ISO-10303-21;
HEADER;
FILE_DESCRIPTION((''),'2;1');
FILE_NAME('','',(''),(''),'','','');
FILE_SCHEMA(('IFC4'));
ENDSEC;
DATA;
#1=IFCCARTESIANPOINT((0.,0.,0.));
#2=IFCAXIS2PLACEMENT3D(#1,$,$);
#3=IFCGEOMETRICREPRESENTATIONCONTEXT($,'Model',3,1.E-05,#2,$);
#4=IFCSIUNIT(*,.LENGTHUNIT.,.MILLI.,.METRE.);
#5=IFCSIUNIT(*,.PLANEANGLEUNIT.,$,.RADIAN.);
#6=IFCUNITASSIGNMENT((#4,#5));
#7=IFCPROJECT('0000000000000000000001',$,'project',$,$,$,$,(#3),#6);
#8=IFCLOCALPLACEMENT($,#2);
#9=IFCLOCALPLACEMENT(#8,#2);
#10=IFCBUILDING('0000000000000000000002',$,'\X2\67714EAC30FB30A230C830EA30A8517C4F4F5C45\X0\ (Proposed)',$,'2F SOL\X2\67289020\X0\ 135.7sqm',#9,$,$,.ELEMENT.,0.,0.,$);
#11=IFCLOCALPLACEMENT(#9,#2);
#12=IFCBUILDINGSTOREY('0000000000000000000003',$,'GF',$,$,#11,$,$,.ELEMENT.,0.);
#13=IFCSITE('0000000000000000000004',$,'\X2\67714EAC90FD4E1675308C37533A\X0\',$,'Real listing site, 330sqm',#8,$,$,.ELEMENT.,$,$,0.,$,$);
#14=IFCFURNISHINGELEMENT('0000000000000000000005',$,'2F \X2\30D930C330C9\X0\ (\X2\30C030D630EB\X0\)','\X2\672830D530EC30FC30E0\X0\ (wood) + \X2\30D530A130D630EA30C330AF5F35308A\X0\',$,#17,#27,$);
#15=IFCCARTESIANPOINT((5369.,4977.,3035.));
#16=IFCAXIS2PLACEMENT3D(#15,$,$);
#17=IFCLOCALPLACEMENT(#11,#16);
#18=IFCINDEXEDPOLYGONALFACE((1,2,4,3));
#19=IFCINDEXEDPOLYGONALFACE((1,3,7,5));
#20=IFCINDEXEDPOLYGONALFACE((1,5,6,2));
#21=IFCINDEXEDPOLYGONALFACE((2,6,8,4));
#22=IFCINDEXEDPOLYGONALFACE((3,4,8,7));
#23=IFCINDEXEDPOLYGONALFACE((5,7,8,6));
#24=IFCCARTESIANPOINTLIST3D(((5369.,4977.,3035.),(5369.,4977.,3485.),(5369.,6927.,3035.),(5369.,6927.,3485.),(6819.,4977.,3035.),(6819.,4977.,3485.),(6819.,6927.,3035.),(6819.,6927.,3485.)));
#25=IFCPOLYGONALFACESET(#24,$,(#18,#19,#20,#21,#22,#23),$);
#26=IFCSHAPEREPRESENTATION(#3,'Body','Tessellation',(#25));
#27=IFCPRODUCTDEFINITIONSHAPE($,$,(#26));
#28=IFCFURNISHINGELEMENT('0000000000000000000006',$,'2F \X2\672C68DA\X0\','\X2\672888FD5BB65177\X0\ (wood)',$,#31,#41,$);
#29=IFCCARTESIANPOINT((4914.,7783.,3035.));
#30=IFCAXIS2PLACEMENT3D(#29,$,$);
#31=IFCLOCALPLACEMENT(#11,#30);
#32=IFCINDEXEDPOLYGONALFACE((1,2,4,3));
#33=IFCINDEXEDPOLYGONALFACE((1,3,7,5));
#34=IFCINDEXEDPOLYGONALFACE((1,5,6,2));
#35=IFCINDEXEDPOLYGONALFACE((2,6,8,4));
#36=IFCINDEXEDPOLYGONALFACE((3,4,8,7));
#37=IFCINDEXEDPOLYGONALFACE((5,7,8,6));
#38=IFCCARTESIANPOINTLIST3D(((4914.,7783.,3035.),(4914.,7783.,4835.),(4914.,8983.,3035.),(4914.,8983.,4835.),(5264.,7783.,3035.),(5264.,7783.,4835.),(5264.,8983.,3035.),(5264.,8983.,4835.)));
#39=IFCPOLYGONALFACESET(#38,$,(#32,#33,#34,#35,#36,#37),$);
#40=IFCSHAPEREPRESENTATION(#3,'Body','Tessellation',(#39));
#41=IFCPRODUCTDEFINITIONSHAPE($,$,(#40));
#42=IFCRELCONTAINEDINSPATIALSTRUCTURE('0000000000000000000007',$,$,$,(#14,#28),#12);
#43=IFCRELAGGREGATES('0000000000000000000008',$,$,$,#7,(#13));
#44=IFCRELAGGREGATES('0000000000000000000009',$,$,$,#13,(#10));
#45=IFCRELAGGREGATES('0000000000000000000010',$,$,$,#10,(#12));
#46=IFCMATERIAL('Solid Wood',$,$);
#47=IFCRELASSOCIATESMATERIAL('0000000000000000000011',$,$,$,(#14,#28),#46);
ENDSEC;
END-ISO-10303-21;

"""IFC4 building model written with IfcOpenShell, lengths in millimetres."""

from ifc_helpers import new_model, si_unit, frame, frame_2d, origin, place, context, project, spatial, rectangle, extrude, material, element, save


model = new_model("IFC4")

# Units and contexts
model_context = context("Model", 3, precision=1e-05, world=origin())
ifc_project = project(units=[si_unit("LENGTHUNIT", "METRE", prefix="MILLI"), si_unit("PLANEANGLEUNIT", "RADIAN")], contexts=[model_context])

# Site, building, storey
site_placement = place(None, origin())
site = spatial("IfcSite", under=ifc_project, at=site_placement, Name="東京都世田谷区", ObjectType="Real listing site, 330sqm", CompositionType="ELEMENT", RefElevation=0.0)
building_placement = place(site_placement, origin())
building = spatial("IfcBuilding", under=site, at=building_placement, Name="東京・アトリエ兼住居 (Proposed)", ObjectType="2F SOL木造 135.7sqm", CompositionType="ELEMENT", ElevationOfRefHeight=0.0, ElevationOfTerrain=0.0)
storey_placement = place(building_placement, origin())
storey = spatial("IfcBuildingStorey", under=building, at=storey_placement, Name="GF", CompositionType="ELEMENT", Elevation=0.0)

# Shared definitions
ifc_material_1 = material(Name="Solid Wood")

# Furnishing elements
furnishing_1_placement = place(storey_placement, frame((5369.0, 4977.0, 3035.0)))
element("IfcFurnishingElement", 1, at=furnishing_1_placement, inside=storey, material=ifc_material_1, Name="2F ベッド (ダブル)", Description="木フレーム (wood) + ファブリック張り", context=model_context, shape_type="SweptSolid", body=[
    extrude(rectangle(XDim=1450.0, YDim=1950.0, at=frame_2d((725.0, 975.0))), frame((5369.0, 4977.0, 3035.0)), (0.0, 0.0, 1.0), 450.0),
])
furnishing_2_placement = place(storey_placement, frame((4914.0, 7783.0, 3035.0)))
element("IfcFurnishingElement", 2, at=furnishing_2_placement, inside=storey, material=ifc_material_1, Name="2F 本棚", Description="木製家具 (wood)", context=model_context, shape_type="SweptSolid", body=[
    extrude(rectangle(XDim=350.0, YDim=1200.0, at=frame_2d((175.0, 600.0))), frame((4914.0, 7783.0, 3035.0)), (0.0, 0.0, 1.0), 1800.0),
])

save(model, "model.ifc")
